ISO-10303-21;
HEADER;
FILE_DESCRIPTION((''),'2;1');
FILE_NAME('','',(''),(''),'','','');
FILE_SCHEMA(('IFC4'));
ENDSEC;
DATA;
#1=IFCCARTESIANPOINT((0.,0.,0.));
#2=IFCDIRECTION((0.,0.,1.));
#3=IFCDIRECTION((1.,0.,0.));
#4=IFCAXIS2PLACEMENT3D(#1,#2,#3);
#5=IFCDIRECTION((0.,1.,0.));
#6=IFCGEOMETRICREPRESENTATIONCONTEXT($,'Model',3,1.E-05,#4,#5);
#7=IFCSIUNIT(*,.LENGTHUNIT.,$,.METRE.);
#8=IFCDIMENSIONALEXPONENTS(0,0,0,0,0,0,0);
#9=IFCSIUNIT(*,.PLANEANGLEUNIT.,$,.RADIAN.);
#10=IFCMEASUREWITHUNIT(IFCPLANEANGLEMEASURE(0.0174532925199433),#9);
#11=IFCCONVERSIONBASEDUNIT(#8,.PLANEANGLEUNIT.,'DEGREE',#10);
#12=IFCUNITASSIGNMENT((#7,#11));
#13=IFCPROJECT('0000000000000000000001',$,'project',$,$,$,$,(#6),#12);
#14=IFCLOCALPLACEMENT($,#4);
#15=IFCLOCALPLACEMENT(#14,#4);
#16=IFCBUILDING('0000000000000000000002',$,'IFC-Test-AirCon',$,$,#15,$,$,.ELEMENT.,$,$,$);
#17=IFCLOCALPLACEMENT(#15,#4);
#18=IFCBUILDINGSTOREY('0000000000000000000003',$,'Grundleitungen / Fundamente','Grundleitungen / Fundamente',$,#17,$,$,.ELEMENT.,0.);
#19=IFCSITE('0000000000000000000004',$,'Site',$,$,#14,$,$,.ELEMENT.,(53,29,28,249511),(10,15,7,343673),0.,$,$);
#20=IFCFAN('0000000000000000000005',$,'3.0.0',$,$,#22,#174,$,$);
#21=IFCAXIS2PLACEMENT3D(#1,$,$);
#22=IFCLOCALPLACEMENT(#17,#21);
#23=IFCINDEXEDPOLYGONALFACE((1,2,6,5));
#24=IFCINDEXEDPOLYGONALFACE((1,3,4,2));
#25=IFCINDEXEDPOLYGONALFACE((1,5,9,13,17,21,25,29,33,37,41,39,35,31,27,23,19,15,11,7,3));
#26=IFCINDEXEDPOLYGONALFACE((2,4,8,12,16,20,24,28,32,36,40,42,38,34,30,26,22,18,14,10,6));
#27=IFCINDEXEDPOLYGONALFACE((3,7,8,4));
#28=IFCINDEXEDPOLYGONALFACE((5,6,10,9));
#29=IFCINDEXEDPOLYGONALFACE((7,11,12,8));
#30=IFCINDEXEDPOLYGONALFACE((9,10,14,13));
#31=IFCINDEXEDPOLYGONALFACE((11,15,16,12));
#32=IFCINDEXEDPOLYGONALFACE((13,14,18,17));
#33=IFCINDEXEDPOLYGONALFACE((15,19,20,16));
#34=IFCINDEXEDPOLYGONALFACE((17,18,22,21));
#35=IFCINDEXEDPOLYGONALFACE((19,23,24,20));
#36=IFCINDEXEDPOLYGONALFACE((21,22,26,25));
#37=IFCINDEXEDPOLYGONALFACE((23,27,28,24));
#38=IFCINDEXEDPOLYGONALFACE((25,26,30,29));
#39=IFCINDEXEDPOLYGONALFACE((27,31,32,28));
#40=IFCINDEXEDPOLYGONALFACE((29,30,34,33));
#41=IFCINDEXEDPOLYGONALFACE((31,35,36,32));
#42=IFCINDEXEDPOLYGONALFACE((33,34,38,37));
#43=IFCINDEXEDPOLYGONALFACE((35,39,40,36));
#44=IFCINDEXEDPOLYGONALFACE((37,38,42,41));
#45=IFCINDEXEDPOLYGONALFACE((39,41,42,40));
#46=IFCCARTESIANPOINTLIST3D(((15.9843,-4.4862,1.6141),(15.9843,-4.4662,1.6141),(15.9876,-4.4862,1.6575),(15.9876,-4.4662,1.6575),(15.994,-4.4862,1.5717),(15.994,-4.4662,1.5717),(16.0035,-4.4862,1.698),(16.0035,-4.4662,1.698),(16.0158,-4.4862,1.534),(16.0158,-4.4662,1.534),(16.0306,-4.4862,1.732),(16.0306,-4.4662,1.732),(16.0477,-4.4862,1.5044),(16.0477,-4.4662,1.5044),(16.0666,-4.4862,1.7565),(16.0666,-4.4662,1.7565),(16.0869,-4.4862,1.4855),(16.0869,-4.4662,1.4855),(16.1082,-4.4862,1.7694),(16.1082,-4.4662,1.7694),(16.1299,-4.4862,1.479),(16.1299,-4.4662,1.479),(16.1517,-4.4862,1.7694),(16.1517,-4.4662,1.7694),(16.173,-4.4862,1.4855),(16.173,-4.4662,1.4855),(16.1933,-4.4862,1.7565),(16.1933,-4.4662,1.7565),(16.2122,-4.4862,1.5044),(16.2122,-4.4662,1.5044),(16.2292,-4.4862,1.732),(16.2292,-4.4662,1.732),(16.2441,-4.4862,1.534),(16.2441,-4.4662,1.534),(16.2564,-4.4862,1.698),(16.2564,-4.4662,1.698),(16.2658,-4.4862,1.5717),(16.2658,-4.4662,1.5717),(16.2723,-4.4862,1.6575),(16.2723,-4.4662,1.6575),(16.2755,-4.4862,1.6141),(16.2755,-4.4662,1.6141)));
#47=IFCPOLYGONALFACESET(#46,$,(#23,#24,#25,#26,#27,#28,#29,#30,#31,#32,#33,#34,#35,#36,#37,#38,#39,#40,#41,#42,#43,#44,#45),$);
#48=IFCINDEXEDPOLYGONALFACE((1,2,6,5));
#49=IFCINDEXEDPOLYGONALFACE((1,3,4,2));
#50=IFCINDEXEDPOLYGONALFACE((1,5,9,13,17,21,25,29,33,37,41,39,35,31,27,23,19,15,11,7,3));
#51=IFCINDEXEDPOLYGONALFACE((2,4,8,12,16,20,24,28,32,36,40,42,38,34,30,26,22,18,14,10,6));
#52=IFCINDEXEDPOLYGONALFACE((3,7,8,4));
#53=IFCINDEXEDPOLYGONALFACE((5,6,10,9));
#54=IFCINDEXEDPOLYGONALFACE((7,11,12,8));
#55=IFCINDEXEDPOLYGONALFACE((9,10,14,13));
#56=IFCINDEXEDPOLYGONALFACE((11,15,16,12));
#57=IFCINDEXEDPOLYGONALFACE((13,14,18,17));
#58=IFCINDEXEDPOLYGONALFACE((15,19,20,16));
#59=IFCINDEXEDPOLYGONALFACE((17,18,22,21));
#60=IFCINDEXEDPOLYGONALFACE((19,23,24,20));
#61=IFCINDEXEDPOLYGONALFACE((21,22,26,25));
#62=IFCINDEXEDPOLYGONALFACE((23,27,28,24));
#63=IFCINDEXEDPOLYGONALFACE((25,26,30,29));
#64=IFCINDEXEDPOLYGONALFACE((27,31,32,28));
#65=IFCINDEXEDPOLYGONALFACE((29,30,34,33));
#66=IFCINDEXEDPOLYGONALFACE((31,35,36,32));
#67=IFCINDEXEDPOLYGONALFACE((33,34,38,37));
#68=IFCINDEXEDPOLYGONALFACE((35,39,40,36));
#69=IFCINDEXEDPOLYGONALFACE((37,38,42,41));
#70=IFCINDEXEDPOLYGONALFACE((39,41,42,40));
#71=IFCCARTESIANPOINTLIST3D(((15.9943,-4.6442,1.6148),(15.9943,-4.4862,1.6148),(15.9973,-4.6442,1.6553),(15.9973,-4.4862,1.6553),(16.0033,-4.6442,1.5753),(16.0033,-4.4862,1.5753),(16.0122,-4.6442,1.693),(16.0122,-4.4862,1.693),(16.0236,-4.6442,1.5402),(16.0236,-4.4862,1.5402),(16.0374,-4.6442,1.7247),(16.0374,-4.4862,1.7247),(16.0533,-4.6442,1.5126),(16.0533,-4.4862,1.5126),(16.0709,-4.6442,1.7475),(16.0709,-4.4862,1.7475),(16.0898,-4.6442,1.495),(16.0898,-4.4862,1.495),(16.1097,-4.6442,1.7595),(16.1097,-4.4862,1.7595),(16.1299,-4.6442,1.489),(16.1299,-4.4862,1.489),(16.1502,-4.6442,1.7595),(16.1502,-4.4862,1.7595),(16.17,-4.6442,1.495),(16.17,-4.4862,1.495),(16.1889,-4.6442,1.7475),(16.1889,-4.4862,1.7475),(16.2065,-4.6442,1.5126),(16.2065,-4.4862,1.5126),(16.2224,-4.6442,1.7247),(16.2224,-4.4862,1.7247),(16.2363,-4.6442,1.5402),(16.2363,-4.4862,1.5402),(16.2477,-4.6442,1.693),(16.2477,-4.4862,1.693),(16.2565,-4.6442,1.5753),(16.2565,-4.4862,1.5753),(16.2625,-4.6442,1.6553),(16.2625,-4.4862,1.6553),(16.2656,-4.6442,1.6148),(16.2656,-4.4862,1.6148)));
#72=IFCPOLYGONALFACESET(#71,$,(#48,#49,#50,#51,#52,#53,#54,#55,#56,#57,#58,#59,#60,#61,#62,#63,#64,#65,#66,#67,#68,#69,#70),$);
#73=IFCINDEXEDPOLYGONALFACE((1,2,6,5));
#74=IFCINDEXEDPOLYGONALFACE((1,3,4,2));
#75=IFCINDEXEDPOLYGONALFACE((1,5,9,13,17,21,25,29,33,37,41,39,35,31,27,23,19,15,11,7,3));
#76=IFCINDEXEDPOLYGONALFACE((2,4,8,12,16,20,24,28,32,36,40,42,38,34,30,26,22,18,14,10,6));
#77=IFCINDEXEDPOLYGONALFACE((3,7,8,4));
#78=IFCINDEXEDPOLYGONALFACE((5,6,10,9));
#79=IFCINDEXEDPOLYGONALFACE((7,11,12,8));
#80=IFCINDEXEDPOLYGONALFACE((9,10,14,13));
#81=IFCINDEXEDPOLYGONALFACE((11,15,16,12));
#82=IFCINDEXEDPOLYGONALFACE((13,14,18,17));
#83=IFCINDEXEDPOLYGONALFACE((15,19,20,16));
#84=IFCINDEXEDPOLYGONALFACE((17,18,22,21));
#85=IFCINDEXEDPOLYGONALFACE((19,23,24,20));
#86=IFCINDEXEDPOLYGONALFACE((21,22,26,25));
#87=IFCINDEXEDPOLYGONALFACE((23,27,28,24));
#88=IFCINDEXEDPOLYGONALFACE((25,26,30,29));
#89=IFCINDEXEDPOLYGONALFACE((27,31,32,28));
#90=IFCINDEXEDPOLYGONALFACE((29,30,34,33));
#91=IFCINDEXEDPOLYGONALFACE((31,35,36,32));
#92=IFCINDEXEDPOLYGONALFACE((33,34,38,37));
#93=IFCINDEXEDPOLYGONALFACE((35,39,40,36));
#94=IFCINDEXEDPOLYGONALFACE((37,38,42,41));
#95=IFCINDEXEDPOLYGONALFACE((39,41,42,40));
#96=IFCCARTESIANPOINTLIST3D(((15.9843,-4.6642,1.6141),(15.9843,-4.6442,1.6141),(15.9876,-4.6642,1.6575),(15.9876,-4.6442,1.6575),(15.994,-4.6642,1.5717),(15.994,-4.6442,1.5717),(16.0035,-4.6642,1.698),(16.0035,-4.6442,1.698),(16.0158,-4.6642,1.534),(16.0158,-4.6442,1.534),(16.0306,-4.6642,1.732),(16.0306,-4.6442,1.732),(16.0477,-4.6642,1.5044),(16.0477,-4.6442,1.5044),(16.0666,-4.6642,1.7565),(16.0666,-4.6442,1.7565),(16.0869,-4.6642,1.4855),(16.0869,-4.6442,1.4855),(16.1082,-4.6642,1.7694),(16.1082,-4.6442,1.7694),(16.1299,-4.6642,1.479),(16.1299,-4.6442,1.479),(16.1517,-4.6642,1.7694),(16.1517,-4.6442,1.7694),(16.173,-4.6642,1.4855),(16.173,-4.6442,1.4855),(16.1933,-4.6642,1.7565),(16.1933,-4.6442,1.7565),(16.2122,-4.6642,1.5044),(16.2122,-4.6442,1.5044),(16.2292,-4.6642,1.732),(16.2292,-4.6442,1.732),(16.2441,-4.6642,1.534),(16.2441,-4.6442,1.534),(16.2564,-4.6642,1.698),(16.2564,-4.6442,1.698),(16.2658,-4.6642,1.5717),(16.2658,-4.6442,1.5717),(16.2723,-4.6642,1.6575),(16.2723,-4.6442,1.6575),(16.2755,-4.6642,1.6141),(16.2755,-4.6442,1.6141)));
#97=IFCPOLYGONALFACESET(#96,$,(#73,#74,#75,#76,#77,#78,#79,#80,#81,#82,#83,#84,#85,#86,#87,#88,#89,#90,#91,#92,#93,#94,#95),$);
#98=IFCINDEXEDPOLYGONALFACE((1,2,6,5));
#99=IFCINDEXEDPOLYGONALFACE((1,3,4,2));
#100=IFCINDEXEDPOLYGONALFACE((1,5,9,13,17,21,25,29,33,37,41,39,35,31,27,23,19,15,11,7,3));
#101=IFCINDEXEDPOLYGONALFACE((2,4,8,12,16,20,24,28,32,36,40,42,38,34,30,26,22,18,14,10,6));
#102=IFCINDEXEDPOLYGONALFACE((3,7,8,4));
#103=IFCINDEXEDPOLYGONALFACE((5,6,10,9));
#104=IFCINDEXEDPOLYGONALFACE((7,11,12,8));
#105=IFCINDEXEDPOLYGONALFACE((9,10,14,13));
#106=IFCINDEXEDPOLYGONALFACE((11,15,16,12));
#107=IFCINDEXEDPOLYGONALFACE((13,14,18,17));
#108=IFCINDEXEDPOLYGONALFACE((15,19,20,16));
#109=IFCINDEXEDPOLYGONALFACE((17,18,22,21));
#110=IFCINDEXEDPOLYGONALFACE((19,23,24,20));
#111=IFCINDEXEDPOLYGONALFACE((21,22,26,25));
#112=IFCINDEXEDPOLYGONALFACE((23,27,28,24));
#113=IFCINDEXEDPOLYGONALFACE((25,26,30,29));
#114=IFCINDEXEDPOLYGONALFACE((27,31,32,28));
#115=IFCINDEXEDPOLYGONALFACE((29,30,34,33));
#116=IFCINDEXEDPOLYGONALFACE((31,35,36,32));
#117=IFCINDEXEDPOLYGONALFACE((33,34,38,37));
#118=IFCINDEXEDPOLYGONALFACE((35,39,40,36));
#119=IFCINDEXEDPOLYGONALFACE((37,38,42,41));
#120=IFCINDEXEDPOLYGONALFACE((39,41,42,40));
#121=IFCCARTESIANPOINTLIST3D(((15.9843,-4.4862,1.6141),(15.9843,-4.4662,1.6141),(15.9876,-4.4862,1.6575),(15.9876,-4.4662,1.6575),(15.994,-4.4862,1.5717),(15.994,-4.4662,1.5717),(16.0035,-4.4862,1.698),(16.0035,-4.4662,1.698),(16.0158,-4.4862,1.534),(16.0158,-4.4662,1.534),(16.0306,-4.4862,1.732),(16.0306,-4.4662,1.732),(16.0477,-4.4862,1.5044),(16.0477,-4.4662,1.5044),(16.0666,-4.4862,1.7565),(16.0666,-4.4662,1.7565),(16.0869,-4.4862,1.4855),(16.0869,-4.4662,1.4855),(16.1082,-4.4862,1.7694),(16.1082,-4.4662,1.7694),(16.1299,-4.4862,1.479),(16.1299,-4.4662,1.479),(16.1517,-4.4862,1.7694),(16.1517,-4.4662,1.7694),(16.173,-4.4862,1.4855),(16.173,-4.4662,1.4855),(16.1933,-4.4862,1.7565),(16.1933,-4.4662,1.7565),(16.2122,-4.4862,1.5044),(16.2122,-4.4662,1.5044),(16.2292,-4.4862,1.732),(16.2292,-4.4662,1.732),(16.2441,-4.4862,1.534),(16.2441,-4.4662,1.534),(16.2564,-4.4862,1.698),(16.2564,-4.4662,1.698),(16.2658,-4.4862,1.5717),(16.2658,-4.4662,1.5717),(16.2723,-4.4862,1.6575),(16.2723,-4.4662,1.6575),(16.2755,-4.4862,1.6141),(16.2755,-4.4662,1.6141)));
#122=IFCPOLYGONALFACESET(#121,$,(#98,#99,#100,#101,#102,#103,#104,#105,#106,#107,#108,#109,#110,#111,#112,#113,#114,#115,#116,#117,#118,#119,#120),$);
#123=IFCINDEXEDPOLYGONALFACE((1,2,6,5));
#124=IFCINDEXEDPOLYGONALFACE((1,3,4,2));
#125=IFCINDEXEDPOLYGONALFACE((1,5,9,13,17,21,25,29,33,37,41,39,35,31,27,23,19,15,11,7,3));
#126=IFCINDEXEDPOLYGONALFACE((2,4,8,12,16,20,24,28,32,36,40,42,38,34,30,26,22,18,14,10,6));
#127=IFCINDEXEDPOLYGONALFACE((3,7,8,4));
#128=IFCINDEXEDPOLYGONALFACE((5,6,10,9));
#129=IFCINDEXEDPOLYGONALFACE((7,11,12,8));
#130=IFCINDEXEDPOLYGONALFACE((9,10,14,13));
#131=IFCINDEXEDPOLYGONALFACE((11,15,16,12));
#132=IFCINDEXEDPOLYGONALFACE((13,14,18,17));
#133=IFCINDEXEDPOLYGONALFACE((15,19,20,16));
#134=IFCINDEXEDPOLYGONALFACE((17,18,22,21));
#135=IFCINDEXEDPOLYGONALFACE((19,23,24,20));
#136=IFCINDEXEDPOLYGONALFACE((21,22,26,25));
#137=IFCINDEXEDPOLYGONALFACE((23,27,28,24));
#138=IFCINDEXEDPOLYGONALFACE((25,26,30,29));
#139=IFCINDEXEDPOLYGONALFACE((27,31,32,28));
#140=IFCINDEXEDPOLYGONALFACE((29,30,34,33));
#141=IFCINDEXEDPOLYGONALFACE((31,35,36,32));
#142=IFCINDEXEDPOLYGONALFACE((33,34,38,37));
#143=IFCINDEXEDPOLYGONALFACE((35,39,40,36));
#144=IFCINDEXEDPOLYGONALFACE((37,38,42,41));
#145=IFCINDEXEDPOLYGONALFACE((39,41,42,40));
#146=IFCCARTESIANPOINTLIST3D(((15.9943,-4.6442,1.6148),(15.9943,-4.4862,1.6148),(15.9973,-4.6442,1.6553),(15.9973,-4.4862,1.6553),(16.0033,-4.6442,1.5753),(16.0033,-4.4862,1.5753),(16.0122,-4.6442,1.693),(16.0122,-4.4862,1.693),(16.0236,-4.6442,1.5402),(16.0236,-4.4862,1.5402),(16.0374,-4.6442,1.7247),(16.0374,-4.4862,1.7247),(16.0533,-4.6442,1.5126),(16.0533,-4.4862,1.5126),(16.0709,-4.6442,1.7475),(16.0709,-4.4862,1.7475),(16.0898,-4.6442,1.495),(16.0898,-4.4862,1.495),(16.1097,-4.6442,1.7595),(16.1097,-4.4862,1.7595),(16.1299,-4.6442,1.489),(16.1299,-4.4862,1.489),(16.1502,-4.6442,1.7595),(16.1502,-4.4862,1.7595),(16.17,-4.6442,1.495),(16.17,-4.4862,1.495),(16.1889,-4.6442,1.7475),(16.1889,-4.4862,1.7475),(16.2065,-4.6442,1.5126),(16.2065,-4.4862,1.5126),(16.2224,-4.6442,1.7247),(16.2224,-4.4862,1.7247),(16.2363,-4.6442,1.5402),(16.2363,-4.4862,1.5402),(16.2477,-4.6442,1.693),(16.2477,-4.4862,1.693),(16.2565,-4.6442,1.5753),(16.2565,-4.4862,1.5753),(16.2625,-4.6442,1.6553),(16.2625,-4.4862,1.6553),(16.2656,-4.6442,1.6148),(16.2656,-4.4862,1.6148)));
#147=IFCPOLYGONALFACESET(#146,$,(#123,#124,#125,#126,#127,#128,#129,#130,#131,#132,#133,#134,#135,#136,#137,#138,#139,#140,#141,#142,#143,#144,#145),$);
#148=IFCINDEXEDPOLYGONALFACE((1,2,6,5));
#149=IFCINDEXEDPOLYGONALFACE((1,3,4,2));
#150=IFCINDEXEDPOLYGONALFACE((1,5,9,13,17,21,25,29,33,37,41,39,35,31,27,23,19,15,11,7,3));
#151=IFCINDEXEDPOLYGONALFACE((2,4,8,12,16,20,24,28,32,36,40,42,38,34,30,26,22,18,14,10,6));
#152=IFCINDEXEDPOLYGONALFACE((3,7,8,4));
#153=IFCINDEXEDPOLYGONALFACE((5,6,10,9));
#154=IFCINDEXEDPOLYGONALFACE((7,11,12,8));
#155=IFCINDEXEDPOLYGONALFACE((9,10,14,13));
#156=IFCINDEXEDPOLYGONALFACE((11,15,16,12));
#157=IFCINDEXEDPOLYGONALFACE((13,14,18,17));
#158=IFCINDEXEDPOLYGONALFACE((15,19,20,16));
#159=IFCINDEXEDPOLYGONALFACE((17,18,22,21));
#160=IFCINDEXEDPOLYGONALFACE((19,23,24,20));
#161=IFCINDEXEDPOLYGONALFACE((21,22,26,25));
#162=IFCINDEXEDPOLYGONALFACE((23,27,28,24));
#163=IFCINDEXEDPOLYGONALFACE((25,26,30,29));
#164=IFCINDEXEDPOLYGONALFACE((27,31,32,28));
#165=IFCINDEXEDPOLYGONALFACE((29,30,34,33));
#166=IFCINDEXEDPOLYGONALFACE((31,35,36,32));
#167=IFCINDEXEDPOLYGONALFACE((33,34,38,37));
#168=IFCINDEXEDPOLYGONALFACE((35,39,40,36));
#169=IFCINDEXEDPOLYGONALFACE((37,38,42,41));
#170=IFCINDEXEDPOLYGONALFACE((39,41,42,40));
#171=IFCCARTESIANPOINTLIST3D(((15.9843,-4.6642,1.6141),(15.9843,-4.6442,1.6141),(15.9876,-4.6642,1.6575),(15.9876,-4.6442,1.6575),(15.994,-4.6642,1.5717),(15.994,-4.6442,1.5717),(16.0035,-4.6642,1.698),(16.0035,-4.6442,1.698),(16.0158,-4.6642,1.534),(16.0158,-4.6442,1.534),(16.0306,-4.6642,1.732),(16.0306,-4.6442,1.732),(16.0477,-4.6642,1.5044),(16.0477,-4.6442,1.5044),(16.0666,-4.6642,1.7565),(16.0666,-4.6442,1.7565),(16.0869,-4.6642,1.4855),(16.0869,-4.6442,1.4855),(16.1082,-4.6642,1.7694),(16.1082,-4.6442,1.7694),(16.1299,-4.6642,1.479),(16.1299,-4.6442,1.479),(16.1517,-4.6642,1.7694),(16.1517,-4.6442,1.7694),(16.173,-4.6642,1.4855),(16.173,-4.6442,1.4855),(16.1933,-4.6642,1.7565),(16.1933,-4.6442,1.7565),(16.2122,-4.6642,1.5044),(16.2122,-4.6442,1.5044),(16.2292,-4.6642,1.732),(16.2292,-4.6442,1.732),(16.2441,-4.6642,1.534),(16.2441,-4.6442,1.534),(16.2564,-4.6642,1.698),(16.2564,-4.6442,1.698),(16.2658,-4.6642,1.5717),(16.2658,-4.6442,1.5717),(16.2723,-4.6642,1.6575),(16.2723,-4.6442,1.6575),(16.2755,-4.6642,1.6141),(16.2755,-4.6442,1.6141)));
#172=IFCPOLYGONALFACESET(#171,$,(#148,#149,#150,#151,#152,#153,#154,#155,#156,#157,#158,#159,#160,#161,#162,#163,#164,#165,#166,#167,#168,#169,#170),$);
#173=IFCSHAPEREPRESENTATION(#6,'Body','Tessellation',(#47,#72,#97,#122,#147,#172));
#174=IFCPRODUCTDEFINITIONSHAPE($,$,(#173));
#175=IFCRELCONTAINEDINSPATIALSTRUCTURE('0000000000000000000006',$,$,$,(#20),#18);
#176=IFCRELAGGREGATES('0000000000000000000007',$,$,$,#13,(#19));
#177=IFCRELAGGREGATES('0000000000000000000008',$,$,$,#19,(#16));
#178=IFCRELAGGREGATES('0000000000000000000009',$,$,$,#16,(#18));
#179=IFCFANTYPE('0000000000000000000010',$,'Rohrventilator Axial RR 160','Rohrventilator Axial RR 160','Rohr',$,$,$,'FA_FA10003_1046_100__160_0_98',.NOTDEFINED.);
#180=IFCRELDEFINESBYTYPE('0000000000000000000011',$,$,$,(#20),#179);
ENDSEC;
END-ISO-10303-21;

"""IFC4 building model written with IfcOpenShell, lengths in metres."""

from ifc_helpers import new_model, entity, si_unit, converted_unit, direction, frame, origin_with_axes, origin_2d_with_axis, place, context, subcontext, project, spatial, circle, extrude, source, transform, mapped, type_object, element, save


model = new_model("IFC4")

# Units and contexts
model_context = context("Model", 3, precision=1e-05, world=origin_with_axes(), true_north=direction((0.0, 1.0, 0.0)))
body_context = subcontext(model_context, "Body", "Model", "MODEL_VIEW")
ifc_project = project(units=[si_unit("LENGTHUNIT", "METRE"), converted_unit("PLANEANGLEUNIT", "DEGREE", entity("IfcPlaneAngleMeasure", 0.0174532925199433), si_unit("PLANEANGLEUNIT", "RADIAN"), dimensions=[0, 0, 0, 0, 0, 0, 0])], contexts=[model_context])

# Site, building, storey
site_placement = place(None, origin_with_axes())
site = spatial("IfcSite", under=ifc_project, at=site_placement, Name="Site", CompositionType="ELEMENT", RefLatitude=(53, 29, 28, 249511), RefLongitude=(10, 15, 7, 343673), RefElevation=0.0)
building_placement = place(site_placement, origin_with_axes())
building = spatial("IfcBuilding", under=site, at=building_placement, Name="IFC-Test-AirCon", CompositionType="ELEMENT")
storey_placement = place(building_placement, origin_with_axes())
storey = spatial("IfcBuildingStorey", under=building, at=storey_placement, Name="Grundleitungen / Fundamente", Description="Grundleitungen / Fundamente", CompositionType="ELEMENT", Elevation=0.0)

# Fan
fan_type = type_object("IfcFanType", Name="Rohrventilator Axial RR 160", Description="Rohrventilator Axial RR 160", ApplicableOccurrence="Rohr", ElementType="FA_FA10003_1046_100__160_0_98", PredefinedType="NOTDEFINED")
shared_shape_1 = source(origin_with_axes(), body_context, "Body", "SweptSolid", [
    extrude(circle(Radius=0.146, at=origin_2d_with_axis()), frame((-0.099, 0.0, 0.0), z_axis=(1.0, 0.0, 0.0), x_axis=(0.0, 0.0, -1.0)), (0.0, 0.0, 1.0), 0.02),
    extrude(circle(Radius=0.136, at=origin_2d_with_axis()), frame((-0.079, 0.0, 0.0), z_axis=(1.0, 0.0, 0.0), x_axis=(0.0, 0.0, -1.0)), (0.0, 0.0, 1.0), 0.158),
    extrude(circle(Radius=0.146, at=origin_2d_with_axis()), frame((0.079, 0.0, 0.0), z_axis=(1.0, 0.0, 0.0), x_axis=(0.0, 0.0, -1.0)), (0.0, 0.0, 1.0), 0.02),
    extrude(circle(Radius=0.146, at=origin_2d_with_axis()), frame((-0.099, 0.0, 0.0), z_axis=(1.0, 0.0, 0.0), x_axis=(0.0, 0.0, -1.0)), (0.0, 0.0, 1.0), 0.02),
    extrude(circle(Radius=0.136, at=origin_2d_with_axis()), frame((-0.079, 0.0, 0.0), z_axis=(1.0, 0.0, 0.0), x_axis=(0.0, 0.0, -1.0)), (0.0, 0.0, 1.0), 0.158),
    extrude(circle(Radius=0.146, at=origin_2d_with_axis()), frame((0.079, 0.0, 0.0), z_axis=(1.0, 0.0, 0.0), x_axis=(0.0, 0.0, -1.0)), (0.0, 0.0, 1.0), 0.02),
])
fan_placement = place(storey_placement, frame((16.1299, -4.5652, 1.625), z_axis=(0.0, 0.0, 1.0), x_axis=(0.0, -1.0, 0.0)))
element("IfcFan", 1, at=fan_placement, inside=storey, type_object=fan_type, Name="3.0.0", context=model_context, shape_type="MappedRepresentation", body=[
    mapped(shared_shape_1, transform((0.0, 0.0, 0.0), scale=1.0)),
])

save(model, "model.ifc")
